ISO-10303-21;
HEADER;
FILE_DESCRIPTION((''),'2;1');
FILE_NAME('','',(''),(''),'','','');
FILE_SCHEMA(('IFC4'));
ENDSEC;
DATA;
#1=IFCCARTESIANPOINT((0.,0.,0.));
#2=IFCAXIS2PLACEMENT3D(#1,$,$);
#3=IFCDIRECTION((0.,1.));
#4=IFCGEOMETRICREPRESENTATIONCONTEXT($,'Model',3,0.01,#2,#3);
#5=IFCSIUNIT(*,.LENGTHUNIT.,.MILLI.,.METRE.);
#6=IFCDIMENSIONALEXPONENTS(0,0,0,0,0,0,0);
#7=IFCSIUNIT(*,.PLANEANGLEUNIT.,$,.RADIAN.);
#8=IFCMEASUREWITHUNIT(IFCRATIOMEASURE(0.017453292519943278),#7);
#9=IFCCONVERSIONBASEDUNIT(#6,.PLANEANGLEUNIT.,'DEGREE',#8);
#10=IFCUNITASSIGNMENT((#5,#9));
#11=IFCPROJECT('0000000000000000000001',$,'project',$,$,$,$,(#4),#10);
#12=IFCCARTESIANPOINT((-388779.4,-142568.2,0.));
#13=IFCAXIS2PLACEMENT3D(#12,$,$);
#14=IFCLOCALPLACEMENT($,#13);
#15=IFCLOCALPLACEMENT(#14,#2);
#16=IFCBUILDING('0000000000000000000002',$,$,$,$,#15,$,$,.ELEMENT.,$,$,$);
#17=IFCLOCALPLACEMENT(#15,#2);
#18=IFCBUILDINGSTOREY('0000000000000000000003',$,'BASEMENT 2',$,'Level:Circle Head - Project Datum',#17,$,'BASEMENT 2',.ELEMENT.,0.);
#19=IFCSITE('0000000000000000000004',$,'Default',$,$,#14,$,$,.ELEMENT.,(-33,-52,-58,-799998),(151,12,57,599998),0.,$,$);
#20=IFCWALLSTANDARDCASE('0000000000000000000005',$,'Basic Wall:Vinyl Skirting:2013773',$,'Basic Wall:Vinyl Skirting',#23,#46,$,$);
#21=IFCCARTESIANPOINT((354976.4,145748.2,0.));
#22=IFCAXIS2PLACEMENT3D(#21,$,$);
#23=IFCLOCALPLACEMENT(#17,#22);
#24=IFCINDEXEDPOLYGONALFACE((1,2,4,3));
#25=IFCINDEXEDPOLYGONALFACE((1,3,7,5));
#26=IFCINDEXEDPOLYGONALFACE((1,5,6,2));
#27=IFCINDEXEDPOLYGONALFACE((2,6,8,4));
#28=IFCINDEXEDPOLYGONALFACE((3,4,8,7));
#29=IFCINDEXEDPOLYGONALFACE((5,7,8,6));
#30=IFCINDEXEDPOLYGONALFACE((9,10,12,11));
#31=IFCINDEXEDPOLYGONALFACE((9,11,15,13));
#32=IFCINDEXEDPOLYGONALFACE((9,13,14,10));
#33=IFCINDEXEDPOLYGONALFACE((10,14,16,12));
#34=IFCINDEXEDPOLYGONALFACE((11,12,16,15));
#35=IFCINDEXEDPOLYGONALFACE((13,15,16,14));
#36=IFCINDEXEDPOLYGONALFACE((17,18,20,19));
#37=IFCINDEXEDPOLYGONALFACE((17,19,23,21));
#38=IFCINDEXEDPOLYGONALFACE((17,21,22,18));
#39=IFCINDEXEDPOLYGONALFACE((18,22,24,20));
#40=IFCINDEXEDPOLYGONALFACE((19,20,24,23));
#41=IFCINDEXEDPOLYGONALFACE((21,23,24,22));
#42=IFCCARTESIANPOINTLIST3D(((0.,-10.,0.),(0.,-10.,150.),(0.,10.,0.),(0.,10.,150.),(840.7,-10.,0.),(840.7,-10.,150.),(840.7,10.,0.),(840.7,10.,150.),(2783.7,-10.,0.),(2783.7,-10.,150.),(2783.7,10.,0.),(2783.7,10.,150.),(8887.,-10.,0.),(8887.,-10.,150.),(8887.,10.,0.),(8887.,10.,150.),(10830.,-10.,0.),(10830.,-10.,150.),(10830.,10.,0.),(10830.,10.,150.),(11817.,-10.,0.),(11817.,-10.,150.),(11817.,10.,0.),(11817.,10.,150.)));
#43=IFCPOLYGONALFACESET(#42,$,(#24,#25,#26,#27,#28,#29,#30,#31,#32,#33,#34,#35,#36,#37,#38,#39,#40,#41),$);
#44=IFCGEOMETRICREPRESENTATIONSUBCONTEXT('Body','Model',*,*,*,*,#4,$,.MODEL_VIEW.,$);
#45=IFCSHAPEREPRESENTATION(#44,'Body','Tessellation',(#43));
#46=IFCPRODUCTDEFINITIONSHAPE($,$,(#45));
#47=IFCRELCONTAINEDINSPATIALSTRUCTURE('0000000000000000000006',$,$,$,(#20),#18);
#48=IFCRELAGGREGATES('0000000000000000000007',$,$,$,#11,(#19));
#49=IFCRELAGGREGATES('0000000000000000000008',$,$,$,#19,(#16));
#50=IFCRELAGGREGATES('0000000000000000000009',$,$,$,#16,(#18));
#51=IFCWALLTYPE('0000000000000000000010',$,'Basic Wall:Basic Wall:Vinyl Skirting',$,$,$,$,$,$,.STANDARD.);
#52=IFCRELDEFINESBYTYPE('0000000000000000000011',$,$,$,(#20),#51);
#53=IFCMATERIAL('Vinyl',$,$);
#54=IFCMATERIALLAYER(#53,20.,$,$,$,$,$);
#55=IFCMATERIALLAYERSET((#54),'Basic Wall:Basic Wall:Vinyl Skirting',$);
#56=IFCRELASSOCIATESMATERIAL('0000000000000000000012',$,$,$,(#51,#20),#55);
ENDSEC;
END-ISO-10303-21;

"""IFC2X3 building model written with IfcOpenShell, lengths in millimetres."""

from ifc_helpers import new_model, entity, si_unit, converted_unit, direction, frame, frame_2d, origin, origin_2d_with_axis, place, context, subcontext, project, spatial, rectangle, extrude, material, layer, layer_set, layer_usage, type_object, element, save


model = new_model("IFC2X3")

# Units and contexts
model_context = context("Model", 3, precision=0.01, world=origin(), true_north=direction((0.0, 1.0)))
body_context = subcontext(model_context, "Body", "Model", "MODEL_VIEW")
ifc_project = project(units=[si_unit("LENGTHUNIT", "METRE", prefix="MILLI"), converted_unit("PLANEANGLEUNIT", "DEGREE", entity("IfcRatioMeasure", 0.017453292519943278), si_unit("PLANEANGLEUNIT", "RADIAN"), dimensions=[0, 0, 0, 0, 0, 0, 0])], contexts=[model_context])

# Site, building, storey
site_placement = place(None, frame((-388779.4, -142568.2, 0.0)))
site = spatial("IfcSite", under=ifc_project, at=site_placement, Name="Default", CompositionType="ELEMENT", RefLatitude=(-33, -52, -58, -799998), RefLongitude=(151, 12, 57, 599998), RefElevation=0.0)
building_placement = place(site_placement, origin())
building = spatial("IfcBuilding", under=site, at=building_placement, CompositionType="ELEMENT")
storey_placement = place(building_placement, origin())
storey = spatial("IfcBuildingStorey", under=building, at=storey_placement, Name="BASEMENT 2", ObjectType="Level:Circle Head - Project Datum", LongName="BASEMENT 2", CompositionType="ELEMENT", Elevation=0.0)

# Shared definitions
ifc_material_1 = material(Name="Vinyl")

# Wall, openings
ifc_layer_1 = layer(ifc_material_1, 20.0)
ifc_layer_set_1 = layer_set([ifc_layer_1], Name="Basic Wall:Basic Wall:Vinyl Skirting")
ifc_layer_usage_1 = layer_usage(ifc_layer_set_1, "AXIS2", "NEGATIVE", 10.0)
wall_type_1 = type_object("IfcWallType", Name="Basic Wall:Basic Wall:Vinyl Skirting", PredefinedType="STANDARD", material=ifc_layer_set_1)
wall_1_placement = place(storey_placement, frame((354976.4, 145748.2, 0.0)))
wall_1 = element("IfcWallStandardCase", 1, at=wall_1_placement, inside=storey, type_object=wall_type_1, material=ifc_layer_usage_1, Name="Basic Wall:Vinyl Skirting:2013773", ObjectType="Basic Wall:Vinyl Skirting", context=body_context, shape_type="SweptSolid", body=[
    extrude(rectangle(XDim=11817.0, YDim=20.0, at=frame_2d((5908.5, 0.0), x_axis=(-1.0, 0.0))), origin(), (0.0, 0.0, 1.0), 150.0),
])
opening_1_placement = place(wall_1_placement, origin())
element("IfcOpeningElement", 2, at=opening_1_placement, cuts=wall_1, ObjectType="Opening", context=body_context, shape_type="SweptSolid", body=[
    extrude(rectangle(XDim=2082.0, YDim=1943.0, at=origin_2d_with_axis()), frame((9858.5, -10.0, 1041.0), z_axis=(0.0, 1.0, 0.0), x_axis=(0.0, 0.0, -1.0)), (0.0, 0.0, 1.0), 20.0),
])
opening_2_placement = place(wall_1_placement, origin())
element("IfcOpeningElement", 3, at=opening_2_placement, cuts=wall_1, ObjectType="Opening", context=body_context, shape_type="SweptSolid", body=[
    extrude(rectangle(XDim=2082.0, YDim=1943.0, at=origin_2d_with_axis()), frame((1812.2, -10.0, 1041.0), z_axis=(0.0, 1.0, 0.0), x_axis=(0.0, 0.0, -1.0)), (0.0, 0.0, 1.0), 20.0),
])

save(model, "model.ifc")
